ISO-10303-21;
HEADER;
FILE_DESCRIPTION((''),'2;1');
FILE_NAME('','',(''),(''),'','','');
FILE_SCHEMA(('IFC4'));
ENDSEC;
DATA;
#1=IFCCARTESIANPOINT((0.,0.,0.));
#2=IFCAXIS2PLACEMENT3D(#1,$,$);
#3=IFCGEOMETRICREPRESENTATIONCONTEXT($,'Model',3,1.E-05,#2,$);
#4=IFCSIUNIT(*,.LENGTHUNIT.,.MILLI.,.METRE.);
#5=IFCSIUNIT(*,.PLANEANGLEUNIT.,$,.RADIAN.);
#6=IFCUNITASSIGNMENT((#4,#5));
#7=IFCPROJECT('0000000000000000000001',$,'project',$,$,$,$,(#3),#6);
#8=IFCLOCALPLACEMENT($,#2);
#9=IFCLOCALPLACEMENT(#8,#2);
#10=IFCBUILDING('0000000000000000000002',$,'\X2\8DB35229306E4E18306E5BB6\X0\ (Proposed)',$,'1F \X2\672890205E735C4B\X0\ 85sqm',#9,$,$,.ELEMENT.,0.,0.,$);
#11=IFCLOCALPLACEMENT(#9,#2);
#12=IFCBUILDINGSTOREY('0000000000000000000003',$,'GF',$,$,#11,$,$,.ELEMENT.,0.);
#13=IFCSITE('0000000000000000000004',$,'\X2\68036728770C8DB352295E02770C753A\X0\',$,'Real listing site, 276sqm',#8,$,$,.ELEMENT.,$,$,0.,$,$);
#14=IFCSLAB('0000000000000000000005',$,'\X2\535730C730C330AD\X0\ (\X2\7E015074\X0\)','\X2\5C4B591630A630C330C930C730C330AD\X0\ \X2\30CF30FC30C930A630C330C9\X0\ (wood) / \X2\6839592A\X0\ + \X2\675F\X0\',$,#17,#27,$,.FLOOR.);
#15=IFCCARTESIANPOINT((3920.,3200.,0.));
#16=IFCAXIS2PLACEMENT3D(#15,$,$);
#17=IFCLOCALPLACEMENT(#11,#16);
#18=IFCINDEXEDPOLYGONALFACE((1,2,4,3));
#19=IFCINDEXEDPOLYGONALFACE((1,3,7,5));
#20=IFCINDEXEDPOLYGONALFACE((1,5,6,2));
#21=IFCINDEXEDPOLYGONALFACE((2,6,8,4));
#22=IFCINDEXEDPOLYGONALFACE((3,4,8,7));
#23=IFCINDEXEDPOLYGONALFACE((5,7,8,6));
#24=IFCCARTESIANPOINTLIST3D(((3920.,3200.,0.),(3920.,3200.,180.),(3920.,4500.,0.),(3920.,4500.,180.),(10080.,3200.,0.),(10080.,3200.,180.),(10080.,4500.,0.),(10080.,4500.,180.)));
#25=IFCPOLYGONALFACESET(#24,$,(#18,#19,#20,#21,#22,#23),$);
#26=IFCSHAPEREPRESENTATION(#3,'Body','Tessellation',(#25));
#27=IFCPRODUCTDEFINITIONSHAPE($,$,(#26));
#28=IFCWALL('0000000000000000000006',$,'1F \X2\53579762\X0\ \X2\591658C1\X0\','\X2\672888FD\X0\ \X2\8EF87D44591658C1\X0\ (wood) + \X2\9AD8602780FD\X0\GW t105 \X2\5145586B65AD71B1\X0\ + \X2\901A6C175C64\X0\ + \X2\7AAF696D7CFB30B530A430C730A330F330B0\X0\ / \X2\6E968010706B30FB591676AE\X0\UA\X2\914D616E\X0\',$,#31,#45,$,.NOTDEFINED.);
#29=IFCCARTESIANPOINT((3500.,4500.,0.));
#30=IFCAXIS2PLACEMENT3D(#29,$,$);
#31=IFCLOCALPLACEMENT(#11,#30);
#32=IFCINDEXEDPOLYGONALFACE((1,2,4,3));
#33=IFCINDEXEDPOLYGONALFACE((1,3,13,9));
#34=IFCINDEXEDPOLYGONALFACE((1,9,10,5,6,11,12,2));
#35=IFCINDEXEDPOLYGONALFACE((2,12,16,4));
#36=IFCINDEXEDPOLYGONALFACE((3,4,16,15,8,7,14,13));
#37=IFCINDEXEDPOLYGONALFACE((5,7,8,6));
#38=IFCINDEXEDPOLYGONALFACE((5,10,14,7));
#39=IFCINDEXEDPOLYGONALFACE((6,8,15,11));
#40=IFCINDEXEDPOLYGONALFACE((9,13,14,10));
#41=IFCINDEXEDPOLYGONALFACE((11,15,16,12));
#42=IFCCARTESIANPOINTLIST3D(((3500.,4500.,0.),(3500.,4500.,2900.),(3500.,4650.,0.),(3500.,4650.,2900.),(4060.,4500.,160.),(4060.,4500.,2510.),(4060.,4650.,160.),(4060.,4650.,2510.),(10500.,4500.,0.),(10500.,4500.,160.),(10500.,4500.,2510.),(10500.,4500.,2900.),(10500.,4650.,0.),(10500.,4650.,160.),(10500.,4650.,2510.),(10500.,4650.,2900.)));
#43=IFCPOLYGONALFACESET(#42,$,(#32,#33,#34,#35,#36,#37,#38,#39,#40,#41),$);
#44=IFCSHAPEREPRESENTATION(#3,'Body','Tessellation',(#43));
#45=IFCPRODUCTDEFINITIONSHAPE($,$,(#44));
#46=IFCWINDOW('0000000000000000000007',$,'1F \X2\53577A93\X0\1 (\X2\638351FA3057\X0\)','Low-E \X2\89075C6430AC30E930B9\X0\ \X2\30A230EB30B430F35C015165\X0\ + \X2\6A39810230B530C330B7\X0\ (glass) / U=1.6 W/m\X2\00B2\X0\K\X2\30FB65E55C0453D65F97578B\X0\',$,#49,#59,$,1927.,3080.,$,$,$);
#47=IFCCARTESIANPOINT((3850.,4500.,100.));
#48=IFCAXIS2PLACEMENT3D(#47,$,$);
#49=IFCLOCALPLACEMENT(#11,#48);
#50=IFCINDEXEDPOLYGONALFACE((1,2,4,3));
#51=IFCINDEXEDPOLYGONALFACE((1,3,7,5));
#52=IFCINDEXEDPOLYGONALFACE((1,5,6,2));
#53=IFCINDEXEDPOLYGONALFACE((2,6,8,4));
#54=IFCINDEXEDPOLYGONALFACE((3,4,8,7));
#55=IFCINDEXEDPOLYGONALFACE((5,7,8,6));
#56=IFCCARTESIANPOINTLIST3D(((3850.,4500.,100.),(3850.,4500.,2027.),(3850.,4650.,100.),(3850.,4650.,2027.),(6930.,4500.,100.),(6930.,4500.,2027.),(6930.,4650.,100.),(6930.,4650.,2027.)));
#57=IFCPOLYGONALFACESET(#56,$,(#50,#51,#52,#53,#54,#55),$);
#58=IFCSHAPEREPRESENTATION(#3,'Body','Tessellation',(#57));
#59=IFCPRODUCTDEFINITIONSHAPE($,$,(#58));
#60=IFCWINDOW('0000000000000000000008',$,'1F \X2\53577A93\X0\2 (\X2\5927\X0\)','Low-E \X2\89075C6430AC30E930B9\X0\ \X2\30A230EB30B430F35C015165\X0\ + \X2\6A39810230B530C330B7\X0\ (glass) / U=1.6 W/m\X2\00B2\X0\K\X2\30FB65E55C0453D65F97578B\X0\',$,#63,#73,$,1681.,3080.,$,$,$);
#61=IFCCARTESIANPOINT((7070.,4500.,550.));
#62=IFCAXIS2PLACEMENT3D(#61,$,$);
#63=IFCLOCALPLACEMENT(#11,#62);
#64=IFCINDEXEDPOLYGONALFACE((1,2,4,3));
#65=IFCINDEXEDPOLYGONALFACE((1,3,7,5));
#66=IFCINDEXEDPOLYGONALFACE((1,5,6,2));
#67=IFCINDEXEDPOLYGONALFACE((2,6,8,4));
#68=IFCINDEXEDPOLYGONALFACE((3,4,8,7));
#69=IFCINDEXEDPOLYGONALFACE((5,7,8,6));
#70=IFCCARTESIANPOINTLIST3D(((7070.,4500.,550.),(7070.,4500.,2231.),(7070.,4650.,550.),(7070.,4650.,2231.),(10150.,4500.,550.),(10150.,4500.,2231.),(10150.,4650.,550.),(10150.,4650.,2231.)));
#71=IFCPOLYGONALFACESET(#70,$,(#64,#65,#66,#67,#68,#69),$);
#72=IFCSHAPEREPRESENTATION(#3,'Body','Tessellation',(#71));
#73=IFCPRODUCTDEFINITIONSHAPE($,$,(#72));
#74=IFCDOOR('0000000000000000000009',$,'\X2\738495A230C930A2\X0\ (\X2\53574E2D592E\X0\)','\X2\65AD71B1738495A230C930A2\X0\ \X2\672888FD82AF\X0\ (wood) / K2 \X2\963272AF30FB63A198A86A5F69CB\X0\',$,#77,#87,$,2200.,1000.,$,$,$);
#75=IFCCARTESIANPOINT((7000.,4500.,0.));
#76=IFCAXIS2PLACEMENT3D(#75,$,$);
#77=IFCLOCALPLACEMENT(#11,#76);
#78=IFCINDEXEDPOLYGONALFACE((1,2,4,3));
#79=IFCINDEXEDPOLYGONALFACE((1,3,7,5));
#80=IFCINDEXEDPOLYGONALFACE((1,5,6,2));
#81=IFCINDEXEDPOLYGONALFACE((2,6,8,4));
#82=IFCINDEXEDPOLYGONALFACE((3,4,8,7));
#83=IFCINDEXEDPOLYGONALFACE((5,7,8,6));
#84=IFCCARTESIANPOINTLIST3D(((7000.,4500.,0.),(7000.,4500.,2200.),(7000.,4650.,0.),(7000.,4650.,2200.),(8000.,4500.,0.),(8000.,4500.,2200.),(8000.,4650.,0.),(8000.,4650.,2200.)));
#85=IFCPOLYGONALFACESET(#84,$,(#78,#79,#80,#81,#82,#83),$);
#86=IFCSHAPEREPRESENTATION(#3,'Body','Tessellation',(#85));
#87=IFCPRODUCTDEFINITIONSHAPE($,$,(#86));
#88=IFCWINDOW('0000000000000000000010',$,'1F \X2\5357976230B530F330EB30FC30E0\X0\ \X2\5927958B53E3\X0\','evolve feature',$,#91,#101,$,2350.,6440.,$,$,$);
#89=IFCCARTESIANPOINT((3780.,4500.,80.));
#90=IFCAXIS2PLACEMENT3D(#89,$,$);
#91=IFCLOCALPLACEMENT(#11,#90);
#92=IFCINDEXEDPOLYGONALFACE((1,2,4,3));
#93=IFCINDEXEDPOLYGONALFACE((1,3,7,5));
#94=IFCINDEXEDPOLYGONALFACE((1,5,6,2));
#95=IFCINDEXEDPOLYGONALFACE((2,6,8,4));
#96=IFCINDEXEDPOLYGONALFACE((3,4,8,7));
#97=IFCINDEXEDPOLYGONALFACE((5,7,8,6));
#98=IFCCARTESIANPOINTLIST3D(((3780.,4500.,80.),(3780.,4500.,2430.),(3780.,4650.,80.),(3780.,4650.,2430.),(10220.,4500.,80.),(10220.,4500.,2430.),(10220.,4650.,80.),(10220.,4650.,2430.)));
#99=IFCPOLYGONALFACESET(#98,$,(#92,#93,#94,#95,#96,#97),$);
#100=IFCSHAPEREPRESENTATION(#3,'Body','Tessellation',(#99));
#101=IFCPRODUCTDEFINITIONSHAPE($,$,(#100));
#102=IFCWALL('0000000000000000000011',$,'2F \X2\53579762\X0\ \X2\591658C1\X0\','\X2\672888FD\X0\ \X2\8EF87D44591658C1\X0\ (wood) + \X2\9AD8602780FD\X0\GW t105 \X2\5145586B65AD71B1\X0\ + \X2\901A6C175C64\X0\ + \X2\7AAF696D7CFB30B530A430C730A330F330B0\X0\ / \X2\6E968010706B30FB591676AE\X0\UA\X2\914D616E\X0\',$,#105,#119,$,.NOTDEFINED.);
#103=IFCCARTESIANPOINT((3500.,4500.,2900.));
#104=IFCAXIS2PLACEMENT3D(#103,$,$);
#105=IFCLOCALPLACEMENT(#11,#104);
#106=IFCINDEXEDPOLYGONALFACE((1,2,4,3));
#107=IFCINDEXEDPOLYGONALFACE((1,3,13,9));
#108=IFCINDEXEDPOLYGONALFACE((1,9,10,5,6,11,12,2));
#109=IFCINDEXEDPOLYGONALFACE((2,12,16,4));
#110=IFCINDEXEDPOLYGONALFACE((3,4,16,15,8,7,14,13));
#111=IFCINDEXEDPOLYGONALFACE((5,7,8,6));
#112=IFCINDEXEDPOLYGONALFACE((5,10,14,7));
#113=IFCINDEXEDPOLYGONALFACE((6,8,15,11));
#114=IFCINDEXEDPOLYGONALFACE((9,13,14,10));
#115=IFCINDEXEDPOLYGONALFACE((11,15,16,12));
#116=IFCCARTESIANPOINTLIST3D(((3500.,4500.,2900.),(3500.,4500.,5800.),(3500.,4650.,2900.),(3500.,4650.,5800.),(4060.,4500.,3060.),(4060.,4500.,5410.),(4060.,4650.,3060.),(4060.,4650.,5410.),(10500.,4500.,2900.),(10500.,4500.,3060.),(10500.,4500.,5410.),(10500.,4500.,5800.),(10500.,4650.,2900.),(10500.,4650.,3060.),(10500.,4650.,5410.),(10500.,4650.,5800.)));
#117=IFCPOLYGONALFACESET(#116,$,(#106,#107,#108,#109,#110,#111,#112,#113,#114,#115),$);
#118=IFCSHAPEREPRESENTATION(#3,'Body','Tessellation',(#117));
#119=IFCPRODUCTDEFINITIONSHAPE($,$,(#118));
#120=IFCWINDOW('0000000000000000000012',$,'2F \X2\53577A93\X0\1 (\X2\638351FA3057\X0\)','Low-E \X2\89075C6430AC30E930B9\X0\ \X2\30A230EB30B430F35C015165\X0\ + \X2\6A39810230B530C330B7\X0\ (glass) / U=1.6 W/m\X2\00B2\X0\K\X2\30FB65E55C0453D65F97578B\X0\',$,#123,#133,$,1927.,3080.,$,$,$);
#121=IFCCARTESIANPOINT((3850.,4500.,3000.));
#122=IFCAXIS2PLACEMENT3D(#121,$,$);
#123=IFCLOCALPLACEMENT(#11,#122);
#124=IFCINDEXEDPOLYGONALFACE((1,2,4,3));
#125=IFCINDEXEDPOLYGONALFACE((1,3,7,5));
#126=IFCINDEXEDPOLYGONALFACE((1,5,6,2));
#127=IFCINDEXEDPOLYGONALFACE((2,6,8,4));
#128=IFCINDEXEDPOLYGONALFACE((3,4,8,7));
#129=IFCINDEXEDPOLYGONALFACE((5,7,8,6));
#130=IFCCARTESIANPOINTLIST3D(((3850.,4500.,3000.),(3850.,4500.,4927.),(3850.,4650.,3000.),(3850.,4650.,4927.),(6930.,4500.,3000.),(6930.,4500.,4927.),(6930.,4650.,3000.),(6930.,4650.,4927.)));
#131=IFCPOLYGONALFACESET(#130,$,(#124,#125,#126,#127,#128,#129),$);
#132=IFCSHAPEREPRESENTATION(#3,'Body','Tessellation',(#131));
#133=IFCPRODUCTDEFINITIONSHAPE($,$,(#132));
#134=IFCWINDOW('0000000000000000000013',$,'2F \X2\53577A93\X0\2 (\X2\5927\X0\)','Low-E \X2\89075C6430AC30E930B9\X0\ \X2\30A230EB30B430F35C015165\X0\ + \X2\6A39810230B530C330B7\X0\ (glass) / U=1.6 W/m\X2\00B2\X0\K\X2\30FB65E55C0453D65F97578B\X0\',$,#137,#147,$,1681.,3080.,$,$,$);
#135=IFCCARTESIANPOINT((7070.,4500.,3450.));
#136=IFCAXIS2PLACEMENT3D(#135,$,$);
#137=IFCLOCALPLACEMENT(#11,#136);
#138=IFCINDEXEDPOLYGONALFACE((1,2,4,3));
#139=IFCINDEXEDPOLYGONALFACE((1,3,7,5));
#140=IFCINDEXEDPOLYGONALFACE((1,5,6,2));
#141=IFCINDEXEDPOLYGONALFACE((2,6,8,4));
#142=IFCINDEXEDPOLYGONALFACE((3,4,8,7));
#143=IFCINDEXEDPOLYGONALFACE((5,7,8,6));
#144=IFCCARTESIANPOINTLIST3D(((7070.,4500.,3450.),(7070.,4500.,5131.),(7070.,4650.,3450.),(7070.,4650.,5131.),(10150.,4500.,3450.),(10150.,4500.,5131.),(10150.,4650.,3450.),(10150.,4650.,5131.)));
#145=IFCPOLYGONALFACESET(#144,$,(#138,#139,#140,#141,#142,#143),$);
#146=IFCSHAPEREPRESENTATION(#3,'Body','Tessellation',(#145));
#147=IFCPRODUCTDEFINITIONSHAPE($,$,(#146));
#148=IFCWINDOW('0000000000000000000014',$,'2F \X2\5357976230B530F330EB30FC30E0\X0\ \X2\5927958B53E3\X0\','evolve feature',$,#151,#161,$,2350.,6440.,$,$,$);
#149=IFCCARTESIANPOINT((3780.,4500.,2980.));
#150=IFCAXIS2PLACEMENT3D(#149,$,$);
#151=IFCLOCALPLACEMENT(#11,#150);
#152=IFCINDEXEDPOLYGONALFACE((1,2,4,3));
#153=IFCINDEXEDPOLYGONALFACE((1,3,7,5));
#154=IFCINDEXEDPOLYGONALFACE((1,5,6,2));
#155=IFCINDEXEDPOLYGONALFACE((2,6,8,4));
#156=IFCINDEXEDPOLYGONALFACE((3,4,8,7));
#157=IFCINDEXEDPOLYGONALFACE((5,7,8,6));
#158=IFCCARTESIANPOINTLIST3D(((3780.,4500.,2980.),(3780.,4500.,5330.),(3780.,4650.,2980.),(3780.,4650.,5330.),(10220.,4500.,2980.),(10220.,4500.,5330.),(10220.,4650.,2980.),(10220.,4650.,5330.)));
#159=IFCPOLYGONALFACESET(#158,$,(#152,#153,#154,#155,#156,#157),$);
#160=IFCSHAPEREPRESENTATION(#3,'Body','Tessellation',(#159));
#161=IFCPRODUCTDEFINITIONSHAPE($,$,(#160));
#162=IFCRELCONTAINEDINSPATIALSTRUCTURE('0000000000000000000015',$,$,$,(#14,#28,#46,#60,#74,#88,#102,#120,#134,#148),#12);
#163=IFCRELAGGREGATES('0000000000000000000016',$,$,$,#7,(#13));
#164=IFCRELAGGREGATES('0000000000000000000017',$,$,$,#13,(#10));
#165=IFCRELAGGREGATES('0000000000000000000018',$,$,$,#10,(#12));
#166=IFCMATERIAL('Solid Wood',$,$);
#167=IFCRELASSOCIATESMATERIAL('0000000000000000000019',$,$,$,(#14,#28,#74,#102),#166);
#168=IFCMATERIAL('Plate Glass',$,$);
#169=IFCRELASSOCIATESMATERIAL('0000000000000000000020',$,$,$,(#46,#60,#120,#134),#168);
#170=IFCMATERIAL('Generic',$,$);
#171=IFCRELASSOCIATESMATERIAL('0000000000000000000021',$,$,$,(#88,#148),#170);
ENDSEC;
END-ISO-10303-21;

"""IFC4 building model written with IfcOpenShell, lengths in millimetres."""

from ifc_helpers import new_model, si_unit, frame, frame_2d, origin, place, context, project, spatial, rectangle, extrude, material, element, fill, save


model = new_model("IFC4")

# Units and contexts
model_context = context("Model", 3, precision=1e-05, world=origin())
ifc_project = project(units=[si_unit("LENGTHUNIT", "METRE", prefix="MILLI"), si_unit("PLANEANGLEUNIT", "RADIAN")], contexts=[model_context])

# Site, building, storey
site_placement = place(None, origin())
site = spatial("IfcSite", under=ifc_project, at=site_placement, Name="栃木県足利市県町", ObjectType="Real listing site, 276sqm", CompositionType="ELEMENT", RefElevation=0.0)
building_placement = place(site_placement, origin())
building = spatial("IfcBuilding", under=site, at=building_placement, Name="足利の丘の家 (Proposed)", ObjectType="1F 木造平屋 85sqm", CompositionType="ELEMENT", ElevationOfRefHeight=0.0, ElevationOfTerrain=0.0)
storey_placement = place(building_placement, origin())
storey = spatial("IfcBuildingStorey", under=building, at=storey_placement, Name="GF", CompositionType="ELEMENT", Elevation=0.0)

# Slab
ifc_material_1 = material(Name="Solid Wood")
slab_1_placement = place(storey_placement, frame((3920.0, 3200.0, 0.0)))
element("IfcSlab", 1, at=slab_1_placement, inside=storey, material=ifc_material_1, Name="南デッキ (縁側)", Description="屋外ウッドデッキ ハードウッド (wood) / 根太 + 束", PredefinedType="FLOOR", context=model_context, shape_type="SweptSolid", body=[
    extrude(rectangle(XDim=6160.0, YDim=1300.0, at=frame_2d((3080.0, 650.0))), frame((3920.0, 3200.0, 0.0)), (0.0, 0.0, 1.0), 180.0),
])
ifc_material_2 = material(Name="Generic")

# Wall, openings, windows, door
wall_1_placement = place(storey_placement, frame((3500.0, 4500.0, 0.0)))
wall_1 = element("IfcWall", 2, at=wall_1_placement, inside=storey, material=ifc_material_1, Name="1F 南面 外壁", Description="木製 軸組外壁 (wood) + 高性能GW t105 充填断熱 + 通気層 + 窯業系サイディング / 準耐火・外皮UA配慮", PredefinedType="NOTDEFINED", context=model_context, shape_type="SweptSolid", body=[
    extrude(rectangle(XDim=7000.0, YDim=150.0, at=frame_2d((3500.0, 75.0))), frame((3500.0, 4500.0, 0.0)), (0.0, 0.0, 1.0), 2900.0),
])
opening_1_placement = place(storey_placement, frame((3850.0, 4500.0, 100.0)))
opening_1 = element("IfcOpeningElement", 3, at=opening_1_placement, cuts=wall_1, PredefinedType="NOTDEFINED", context=model_context, shape_type="SweptSolid", body=[
    extrude(rectangle(XDim=3080.0, YDim=150.0, at=frame_2d((1540.0, 75.0))), frame((3850.0, 4500.0, 100.0)), (0.0, 0.0, 1.0), 1927.0),
])
opening_2_placement = place(storey_placement, frame((7070.0, 4500.0, 550.0)))
opening_2 = element("IfcOpeningElement", 4, at=opening_2_placement, cuts=wall_1, PredefinedType="NOTDEFINED", context=model_context, shape_type="SweptSolid", body=[
    extrude(rectangle(XDim=3080.0, YDim=150.0, at=frame_2d((1540.0, 75.0))), frame((7070.0, 4500.0, 550.0)), (0.0, 0.0, 1.0), 1681.0),
])
opening_3_placement = place(storey_placement, frame((7000.0, 4500.0, 0.0)))
opening_3 = element("IfcOpeningElement", 5, at=opening_3_placement, cuts=wall_1, PredefinedType="NOTDEFINED", context=model_context, shape_type="SweptSolid", body=[
    extrude(rectangle(XDim=1000.0, YDim=150.0, at=frame_2d((500.0, 75.0))), frame((7000.0, 4500.0, 0.0)), (0.0, 0.0, 1.0), 2200.0),
])
opening_4_placement = place(storey_placement, frame((3780.0, 4500.0, 80.0)))
opening_4 = element("IfcOpeningElement", 6, at=opening_4_placement, cuts=wall_1, PredefinedType="NOTDEFINED", context=model_context, shape_type="SweptSolid", body=[
    extrude(rectangle(XDim=6440.0, YDim=150.0, at=frame_2d((3220.0, 75.0))), frame((3780.0, 4500.0, 80.0)), (0.0, 0.0, 1.0), 2350.0),
])
ifc_material_3 = material(Name="Plate Glass")
window_1_placement = place(storey_placement, frame((3850.0, 4500.0, 100.0)))
window_1 = element("IfcWindow", 7, at=window_1_placement, inside=storey, material=ifc_material_3, Name="1F 南窓1 (掃出し)", Description="Low-E 複層ガラス アルゴン封入 + 樹脂サッシ (glass) / U=1.6 W/m²K・日射取得型", OverallHeight=1927.0, OverallWidth=3080.0, context=model_context, shape_type="SweptSolid", body=[
    extrude(rectangle(XDim=3080.0, YDim=150.0, at=frame_2d((1540.0, 75.0))), frame((3850.0, 4500.0, 100.0)), (0.0, 0.0, 1.0), 1927.0),
])
fill(opening_1, window_1)
window_2_placement = place(storey_placement, frame((7070.0, 4500.0, 550.0)))
window_2 = element("IfcWindow", 8, at=window_2_placement, inside=storey, material=ifc_material_3, Name="1F 南窓2 (大)", Description="Low-E 複層ガラス アルゴン封入 + 樹脂サッシ (glass) / U=1.6 W/m²K・日射取得型", OverallHeight=1681.0, OverallWidth=3080.0, context=model_context, shape_type="SweptSolid", body=[
    extrude(rectangle(XDim=3080.0, YDim=150.0, at=frame_2d((1540.0, 75.0))), frame((7070.0, 4500.0, 550.0)), (0.0, 0.0, 1.0), 1681.0),
])
fill(opening_2, window_2)
door_placement = place(storey_placement, frame((7000.0, 4500.0, 0.0)))
door = element("IfcDoor", 9, at=door_placement, inside=storey, material=ifc_material_1, Name="玄関ドア (南中央)", Description="断熱玄関ドア 木製芯 (wood) / K2 防犯・採風機構", OverallHeight=2200.0, OverallWidth=1000.0, context=model_context, shape_type="SweptSolid", body=[
    extrude(rectangle(XDim=1000.0, YDim=150.0, at=frame_2d((500.0, 75.0))), frame((7000.0, 4500.0, 0.0)), (0.0, 0.0, 1.0), 2200.0),
])
fill(opening_3, door)
window_3_placement = place(storey_placement, frame((3780.0, 4500.0, 80.0)))
window_3 = element("IfcWindow", 10, at=window_3_placement, inside=storey, material=ifc_material_2, Name="1F 南面サンルーム 大開口", Description="evolve feature", OverallHeight=2350.0, OverallWidth=6440.0, context=model_context, shape_type="SweptSolid", body=[
    extrude(rectangle(XDim=6440.0, YDim=150.0, at=frame_2d((3220.0, 75.0))), frame((3780.0, 4500.0, 80.0)), (0.0, 0.0, 1.0), 2350.0),
])
fill(opening_4, window_3)

# Wall, openings, windows
wall_2_placement = place(storey_placement, frame((3500.0, 4500.0, 2900.0)))
wall_2 = element("IfcWall", 11, at=wall_2_placement, inside=storey, material=ifc_material_1, Name="2F 南面 外壁", Description="木製 軸組外壁 (wood) + 高性能GW t105 充填断熱 + 通気層 + 窯業系サイディング / 準耐火・外皮UA配慮", PredefinedType="NOTDEFINED", context=model_context, shape_type="SweptSolid", body=[
    extrude(rectangle(XDim=7000.0, YDim=150.0, at=frame_2d((3500.0, 75.0))), frame((3500.0, 4500.0, 2900.0)), (0.0, 0.0, 1.0), 2900.0),
])
opening_5_placement = place(storey_placement, frame((3850.0, 4500.0, 3000.0)))
opening_5 = element("IfcOpeningElement", 12, at=opening_5_placement, cuts=wall_2, PredefinedType="NOTDEFINED", context=model_context, shape_type="SweptSolid", body=[
    extrude(rectangle(XDim=3080.0, YDim=150.0, at=frame_2d((1540.0, 75.0))), frame((3850.0, 4500.0, 3000.0)), (0.0, 0.0, 1.0), 1927.0),
])
opening_6_placement = place(storey_placement, frame((7070.0, 4500.0, 3450.0)))
opening_6 = element("IfcOpeningElement", 13, at=opening_6_placement, cuts=wall_2, PredefinedType="NOTDEFINED", context=model_context, shape_type="SweptSolid", body=[
    extrude(rectangle(XDim=3080.0, YDim=150.0, at=frame_2d((1540.0, 75.0))), frame((7070.0, 4500.0, 3450.0)), (0.0, 0.0, 1.0), 1681.0),
])
opening_7_placement = place(storey_placement, frame((3780.0, 4500.0, 2980.0)))
opening_7 = element("IfcOpeningElement", 14, at=opening_7_placement, cuts=wall_2, PredefinedType="NOTDEFINED", context=model_context, shape_type="SweptSolid", body=[
    extrude(rectangle(XDim=6440.0, YDim=150.0, at=frame_2d((3220.0, 75.0))), frame((3780.0, 4500.0, 2980.0)), (0.0, 0.0, 1.0), 2350.0),
])
window_4_placement = place(storey_placement, frame((3850.0, 4500.0, 3000.0)))
window_4 = element("IfcWindow", 15, at=window_4_placement, inside=storey, material=ifc_material_3, Name="2F 南窓1 (掃出し)", Description="Low-E 複層ガラス アルゴン封入 + 樹脂サッシ (glass) / U=1.6 W/m²K・日射取得型", OverallHeight=1927.0, OverallWidth=3080.0, context=model_context, shape_type="SweptSolid", body=[
    extrude(rectangle(XDim=3080.0, YDim=150.0, at=frame_2d((1540.0, 75.0))), frame((3850.0, 4500.0, 3000.0)), (0.0, 0.0, 1.0), 1927.0),
])
fill(opening_5, window_4)
window_5_placement = place(storey_placement, frame((7070.0, 4500.0, 3450.0)))
window_5 = element("IfcWindow", 16, at=window_5_placement, inside=storey, material=ifc_material_3, Name="2F 南窓2 (大)", Description="Low-E 複層ガラス アルゴン封入 + 樹脂サッシ (glass) / U=1.6 W/m²K・日射取得型", OverallHeight=1681.0, OverallWidth=3080.0, context=model_context, shape_type="SweptSolid", body=[
    extrude(rectangle(XDim=3080.0, YDim=150.0, at=frame_2d((1540.0, 75.0))), frame((7070.0, 4500.0, 3450.0)), (0.0, 0.0, 1.0), 1681.0),
])
fill(opening_6, window_5)
window_6_placement = place(storey_placement, frame((3780.0, 4500.0, 2980.0)))
window_6 = element("IfcWindow", 17, at=window_6_placement, inside=storey, material=ifc_material_2, Name="2F 南面サンルーム 大開口", Description="evolve feature", OverallHeight=2350.0, OverallWidth=6440.0, context=model_context, shape_type="SweptSolid", body=[
    extrude(rectangle(XDim=6440.0, YDim=150.0, at=frame_2d((3220.0, 75.0))), frame((3780.0, 4500.0, 2980.0)), (0.0, 0.0, 1.0), 2350.0),
])
fill(opening_7, window_6)

save(model, "model.ifc")
